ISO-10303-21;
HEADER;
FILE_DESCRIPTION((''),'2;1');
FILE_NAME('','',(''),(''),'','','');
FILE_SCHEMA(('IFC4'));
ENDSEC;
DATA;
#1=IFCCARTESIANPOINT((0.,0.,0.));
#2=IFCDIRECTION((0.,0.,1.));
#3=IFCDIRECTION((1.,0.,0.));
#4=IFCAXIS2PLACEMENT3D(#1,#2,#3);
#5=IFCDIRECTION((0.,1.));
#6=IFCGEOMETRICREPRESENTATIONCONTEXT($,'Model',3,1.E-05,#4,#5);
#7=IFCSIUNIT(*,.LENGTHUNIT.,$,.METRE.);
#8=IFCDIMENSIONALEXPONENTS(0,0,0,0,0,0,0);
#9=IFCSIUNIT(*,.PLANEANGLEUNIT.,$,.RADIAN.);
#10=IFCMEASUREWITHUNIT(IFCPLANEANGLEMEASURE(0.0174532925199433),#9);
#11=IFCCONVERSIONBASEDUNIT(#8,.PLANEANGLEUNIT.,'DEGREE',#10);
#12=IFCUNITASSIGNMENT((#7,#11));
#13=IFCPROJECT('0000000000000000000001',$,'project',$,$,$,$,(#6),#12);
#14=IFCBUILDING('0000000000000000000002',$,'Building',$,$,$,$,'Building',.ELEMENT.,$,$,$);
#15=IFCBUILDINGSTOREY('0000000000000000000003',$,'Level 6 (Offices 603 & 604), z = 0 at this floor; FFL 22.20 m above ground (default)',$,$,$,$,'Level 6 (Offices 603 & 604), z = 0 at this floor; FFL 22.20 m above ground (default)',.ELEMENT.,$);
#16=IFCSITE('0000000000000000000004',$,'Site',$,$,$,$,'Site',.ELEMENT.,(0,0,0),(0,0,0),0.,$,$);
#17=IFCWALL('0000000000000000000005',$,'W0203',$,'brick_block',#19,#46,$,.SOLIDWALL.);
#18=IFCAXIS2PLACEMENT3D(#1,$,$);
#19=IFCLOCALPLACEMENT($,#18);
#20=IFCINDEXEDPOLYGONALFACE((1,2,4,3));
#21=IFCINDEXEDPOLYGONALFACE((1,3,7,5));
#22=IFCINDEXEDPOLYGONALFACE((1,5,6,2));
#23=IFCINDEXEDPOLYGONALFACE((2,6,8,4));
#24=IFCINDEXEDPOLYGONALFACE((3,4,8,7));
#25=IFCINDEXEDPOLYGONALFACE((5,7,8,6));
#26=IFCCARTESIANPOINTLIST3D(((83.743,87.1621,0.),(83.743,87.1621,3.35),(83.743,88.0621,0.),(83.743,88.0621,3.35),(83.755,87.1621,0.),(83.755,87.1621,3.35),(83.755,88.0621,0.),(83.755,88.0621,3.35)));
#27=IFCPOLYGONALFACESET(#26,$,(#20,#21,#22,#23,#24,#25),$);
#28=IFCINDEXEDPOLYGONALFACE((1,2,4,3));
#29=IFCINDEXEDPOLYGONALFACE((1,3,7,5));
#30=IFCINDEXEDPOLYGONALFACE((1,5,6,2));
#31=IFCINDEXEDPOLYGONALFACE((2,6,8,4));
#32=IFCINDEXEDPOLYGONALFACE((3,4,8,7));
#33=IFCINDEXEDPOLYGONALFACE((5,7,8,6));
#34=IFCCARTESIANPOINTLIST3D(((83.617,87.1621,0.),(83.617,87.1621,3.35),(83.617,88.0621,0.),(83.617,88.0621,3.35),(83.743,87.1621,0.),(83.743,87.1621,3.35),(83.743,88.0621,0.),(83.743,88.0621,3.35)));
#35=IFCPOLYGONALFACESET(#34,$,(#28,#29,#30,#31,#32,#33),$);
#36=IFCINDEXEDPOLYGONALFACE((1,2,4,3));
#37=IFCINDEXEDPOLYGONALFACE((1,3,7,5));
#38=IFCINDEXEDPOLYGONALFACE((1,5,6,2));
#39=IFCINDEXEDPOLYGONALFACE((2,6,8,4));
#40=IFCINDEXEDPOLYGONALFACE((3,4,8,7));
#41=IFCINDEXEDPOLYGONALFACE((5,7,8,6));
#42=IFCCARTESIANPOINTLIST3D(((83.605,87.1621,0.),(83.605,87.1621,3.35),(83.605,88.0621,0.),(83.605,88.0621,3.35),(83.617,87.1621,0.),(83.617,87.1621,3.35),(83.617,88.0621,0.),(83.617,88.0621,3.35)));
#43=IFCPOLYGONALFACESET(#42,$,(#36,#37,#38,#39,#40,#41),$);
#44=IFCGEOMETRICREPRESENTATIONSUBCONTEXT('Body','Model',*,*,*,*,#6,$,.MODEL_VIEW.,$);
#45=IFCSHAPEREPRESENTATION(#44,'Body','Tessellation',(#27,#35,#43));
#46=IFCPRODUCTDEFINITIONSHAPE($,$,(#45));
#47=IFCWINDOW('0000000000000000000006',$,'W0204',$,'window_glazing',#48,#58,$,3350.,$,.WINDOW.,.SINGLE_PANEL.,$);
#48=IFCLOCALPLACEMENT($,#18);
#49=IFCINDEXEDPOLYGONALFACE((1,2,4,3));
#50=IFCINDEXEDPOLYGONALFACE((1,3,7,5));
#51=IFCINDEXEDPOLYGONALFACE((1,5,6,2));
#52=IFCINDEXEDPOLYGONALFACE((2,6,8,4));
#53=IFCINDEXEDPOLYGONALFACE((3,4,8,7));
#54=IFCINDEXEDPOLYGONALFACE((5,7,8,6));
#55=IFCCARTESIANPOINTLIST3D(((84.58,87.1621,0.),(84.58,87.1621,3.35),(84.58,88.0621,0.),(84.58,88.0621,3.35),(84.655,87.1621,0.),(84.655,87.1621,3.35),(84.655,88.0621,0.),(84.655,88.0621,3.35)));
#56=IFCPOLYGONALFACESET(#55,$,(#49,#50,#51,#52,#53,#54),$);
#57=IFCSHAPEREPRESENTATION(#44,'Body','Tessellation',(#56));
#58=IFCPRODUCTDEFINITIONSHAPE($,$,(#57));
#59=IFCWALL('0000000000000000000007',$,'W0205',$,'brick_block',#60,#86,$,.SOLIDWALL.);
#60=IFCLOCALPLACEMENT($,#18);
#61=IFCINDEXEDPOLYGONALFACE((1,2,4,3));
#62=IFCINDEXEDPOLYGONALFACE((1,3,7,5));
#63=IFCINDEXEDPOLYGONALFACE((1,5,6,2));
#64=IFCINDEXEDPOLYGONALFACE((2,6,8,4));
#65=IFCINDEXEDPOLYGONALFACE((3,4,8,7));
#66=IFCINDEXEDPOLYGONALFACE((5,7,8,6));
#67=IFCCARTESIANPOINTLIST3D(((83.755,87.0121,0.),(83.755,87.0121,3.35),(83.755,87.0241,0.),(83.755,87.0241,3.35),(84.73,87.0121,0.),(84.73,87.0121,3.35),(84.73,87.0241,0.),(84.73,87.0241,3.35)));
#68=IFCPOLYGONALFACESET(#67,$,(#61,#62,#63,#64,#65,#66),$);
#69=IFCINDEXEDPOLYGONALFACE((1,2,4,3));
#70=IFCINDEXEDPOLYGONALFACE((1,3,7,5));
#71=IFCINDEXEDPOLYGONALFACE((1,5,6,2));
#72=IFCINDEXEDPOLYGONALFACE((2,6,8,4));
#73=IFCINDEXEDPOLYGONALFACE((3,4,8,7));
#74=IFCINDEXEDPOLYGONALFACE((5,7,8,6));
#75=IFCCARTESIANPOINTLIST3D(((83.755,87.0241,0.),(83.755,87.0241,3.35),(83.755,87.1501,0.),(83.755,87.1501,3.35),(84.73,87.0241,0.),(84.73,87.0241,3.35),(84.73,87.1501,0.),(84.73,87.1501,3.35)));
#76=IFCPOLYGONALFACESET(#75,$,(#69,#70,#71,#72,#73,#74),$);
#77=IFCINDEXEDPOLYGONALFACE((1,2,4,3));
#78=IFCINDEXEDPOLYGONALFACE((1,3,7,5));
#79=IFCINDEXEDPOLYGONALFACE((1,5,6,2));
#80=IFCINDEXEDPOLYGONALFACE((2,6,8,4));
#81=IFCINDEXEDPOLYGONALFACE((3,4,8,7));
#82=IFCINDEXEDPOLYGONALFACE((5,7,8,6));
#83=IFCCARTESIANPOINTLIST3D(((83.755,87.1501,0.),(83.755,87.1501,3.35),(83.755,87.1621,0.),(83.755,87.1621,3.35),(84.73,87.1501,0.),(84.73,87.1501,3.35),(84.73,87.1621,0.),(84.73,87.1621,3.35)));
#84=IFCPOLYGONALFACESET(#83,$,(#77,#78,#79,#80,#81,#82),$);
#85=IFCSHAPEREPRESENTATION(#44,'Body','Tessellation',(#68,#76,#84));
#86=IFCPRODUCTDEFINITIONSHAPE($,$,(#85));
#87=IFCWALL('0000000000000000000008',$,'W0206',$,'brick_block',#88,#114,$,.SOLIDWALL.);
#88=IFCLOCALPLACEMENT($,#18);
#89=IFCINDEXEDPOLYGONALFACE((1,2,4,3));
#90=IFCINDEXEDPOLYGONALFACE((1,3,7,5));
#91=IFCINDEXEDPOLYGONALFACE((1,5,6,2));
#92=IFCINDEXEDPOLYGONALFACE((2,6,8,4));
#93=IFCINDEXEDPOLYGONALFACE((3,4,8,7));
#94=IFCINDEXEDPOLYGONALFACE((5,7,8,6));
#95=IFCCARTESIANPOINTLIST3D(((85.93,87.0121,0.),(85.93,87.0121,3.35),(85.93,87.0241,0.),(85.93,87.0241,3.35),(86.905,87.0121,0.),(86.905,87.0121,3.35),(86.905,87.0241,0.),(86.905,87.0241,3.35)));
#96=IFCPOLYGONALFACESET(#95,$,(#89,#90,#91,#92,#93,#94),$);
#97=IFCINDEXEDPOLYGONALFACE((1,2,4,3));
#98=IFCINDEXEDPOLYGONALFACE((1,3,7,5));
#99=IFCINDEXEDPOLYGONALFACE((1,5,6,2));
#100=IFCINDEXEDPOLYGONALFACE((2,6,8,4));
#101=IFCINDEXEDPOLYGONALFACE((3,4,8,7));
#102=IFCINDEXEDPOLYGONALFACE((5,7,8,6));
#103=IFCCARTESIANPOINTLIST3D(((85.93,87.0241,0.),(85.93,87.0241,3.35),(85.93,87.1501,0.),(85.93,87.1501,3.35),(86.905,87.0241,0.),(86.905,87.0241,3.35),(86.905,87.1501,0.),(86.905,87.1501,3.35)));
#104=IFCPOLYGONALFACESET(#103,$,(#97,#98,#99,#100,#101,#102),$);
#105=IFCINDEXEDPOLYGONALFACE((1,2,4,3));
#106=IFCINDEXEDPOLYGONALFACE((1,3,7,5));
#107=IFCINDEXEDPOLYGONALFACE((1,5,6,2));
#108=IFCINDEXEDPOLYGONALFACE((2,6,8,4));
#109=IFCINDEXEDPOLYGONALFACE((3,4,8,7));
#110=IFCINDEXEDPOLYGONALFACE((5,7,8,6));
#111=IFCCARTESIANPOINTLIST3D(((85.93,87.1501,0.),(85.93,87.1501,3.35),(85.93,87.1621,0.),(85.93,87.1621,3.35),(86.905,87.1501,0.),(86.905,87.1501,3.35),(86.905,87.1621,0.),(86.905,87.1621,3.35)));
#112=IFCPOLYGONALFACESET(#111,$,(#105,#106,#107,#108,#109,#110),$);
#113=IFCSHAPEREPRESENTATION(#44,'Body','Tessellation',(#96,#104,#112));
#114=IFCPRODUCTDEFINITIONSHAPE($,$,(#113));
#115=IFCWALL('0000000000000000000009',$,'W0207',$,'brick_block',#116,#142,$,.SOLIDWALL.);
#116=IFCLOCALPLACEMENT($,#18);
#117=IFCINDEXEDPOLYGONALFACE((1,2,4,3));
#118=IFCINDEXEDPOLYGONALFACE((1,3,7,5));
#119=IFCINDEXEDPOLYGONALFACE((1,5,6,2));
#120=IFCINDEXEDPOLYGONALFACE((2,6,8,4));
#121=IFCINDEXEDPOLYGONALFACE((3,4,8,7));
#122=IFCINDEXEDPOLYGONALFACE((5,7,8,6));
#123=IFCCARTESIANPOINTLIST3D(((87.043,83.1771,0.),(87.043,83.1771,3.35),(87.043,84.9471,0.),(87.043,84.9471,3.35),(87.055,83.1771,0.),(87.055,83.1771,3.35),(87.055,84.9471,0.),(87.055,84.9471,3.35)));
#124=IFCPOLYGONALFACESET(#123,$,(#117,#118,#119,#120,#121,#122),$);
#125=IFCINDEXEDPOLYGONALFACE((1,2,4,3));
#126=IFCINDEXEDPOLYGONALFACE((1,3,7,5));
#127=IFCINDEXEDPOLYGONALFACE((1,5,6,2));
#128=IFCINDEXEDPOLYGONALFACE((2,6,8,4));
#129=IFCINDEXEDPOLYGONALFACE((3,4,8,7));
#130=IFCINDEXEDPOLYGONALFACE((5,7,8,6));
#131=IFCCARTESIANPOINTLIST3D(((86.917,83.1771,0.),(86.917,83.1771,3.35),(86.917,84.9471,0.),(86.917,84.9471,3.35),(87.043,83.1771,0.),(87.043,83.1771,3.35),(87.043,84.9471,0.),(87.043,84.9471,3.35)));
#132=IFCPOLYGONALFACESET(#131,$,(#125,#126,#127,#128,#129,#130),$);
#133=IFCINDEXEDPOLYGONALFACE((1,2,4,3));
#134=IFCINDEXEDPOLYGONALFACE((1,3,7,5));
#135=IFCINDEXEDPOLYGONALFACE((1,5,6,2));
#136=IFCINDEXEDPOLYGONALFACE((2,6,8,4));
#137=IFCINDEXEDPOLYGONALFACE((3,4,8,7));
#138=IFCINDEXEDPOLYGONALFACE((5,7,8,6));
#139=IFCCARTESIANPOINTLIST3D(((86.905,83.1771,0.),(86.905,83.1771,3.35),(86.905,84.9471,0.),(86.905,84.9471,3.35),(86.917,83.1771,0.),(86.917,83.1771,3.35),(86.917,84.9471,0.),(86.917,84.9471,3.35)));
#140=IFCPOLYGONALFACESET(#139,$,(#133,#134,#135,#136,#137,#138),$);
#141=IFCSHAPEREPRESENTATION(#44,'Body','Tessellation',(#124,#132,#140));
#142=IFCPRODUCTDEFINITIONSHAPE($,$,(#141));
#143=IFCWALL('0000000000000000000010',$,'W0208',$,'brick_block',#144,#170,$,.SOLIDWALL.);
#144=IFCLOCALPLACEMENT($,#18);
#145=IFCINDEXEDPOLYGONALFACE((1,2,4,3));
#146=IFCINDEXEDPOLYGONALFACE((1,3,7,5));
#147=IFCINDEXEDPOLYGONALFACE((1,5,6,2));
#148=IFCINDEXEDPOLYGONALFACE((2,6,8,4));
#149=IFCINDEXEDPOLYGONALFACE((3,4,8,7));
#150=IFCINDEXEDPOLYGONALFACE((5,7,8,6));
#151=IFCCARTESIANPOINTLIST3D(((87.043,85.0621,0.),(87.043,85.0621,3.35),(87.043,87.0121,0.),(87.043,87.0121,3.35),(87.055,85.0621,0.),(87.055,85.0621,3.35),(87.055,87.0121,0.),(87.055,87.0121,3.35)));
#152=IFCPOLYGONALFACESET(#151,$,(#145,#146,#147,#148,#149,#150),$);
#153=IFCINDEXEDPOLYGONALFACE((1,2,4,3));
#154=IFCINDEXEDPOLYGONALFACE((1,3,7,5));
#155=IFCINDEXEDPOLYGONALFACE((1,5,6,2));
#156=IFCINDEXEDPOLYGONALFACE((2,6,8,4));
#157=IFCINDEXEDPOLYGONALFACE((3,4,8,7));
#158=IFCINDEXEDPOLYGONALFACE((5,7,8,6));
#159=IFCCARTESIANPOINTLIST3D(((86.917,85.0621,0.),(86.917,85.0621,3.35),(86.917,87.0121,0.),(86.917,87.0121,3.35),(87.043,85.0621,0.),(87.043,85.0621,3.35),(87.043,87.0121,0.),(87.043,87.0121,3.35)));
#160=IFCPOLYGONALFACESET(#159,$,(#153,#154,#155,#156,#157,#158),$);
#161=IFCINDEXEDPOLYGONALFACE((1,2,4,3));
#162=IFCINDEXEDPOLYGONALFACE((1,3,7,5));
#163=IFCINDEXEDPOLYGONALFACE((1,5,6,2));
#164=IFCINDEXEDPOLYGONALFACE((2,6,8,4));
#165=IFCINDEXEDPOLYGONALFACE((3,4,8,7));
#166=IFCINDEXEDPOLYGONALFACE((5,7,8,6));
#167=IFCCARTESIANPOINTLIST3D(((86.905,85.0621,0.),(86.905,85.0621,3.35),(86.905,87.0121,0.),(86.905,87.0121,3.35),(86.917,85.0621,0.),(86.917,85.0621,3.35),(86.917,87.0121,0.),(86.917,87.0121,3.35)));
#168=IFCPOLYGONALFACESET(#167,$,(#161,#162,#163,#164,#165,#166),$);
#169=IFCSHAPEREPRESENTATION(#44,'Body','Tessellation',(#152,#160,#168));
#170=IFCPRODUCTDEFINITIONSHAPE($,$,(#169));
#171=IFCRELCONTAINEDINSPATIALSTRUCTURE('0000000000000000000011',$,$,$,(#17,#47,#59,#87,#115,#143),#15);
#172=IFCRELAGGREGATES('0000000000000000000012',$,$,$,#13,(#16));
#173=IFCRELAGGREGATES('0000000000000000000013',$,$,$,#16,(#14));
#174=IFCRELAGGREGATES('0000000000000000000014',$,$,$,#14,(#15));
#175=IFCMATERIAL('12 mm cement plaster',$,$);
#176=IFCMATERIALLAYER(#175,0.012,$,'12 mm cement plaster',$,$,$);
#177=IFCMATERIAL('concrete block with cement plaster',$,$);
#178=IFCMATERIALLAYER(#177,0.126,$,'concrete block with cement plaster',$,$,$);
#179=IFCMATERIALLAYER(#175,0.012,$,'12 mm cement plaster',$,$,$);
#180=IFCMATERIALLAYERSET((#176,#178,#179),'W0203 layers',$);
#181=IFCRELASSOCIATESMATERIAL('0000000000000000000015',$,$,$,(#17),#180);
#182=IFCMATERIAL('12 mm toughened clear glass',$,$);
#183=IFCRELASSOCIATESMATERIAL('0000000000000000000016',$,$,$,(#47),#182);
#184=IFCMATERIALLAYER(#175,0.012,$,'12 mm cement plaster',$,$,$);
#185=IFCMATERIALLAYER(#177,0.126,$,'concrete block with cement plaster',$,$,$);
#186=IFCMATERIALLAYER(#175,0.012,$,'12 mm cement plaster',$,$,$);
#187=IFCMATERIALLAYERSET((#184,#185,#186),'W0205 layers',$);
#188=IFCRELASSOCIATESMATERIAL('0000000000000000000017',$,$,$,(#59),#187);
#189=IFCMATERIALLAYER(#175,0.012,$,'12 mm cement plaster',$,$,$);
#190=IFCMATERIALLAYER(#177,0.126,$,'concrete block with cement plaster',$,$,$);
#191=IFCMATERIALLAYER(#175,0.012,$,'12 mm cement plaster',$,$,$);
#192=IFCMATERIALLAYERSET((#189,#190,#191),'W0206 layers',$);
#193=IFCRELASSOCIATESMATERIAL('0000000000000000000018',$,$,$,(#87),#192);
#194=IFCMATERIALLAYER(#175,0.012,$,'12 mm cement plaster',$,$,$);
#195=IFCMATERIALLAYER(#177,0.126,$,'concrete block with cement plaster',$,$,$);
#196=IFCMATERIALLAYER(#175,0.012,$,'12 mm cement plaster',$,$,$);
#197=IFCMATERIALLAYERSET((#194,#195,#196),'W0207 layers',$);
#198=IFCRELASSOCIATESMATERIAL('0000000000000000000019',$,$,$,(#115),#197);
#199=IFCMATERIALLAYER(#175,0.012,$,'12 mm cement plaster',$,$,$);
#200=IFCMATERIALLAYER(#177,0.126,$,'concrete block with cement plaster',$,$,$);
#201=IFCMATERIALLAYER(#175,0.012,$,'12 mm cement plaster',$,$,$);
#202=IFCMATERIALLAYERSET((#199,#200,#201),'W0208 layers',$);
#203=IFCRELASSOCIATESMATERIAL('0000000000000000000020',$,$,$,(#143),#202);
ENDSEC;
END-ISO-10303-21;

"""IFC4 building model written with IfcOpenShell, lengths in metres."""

from ifc_helpers import new_model, entity, si_unit, converted_unit, direction, frame, frame_2d, origin_with_axes, origin_2d_with_axis, place, context, subcontext, project, spatial, rectangle, extrude, material, layer, layer_set, layer_usage, element, save


model = new_model("IFC4")

# Units and contexts
model_context = context("Model", 3, precision=1e-05, world=origin_with_axes(), true_north=direction((0.0, 1.0)))
body_context = subcontext(model_context, "Body", "Model", "MODEL_VIEW")
ifc_project = project(units=[si_unit("LENGTHUNIT", "METRE"), converted_unit("PLANEANGLEUNIT", "DEGREE", entity("IfcPlaneAngleMeasure", 0.0174532925199433), si_unit("PLANEANGLEUNIT", "RADIAN"), dimensions=[0, 0, 0, 0, 0, 0, 0])], contexts=[model_context])

# Site, building, storey
site = spatial("IfcSite", under=ifc_project, Name="Site", LongName="Site", CompositionType="ELEMENT", RefLatitude=(0, 0, 0), RefLongitude=(0, 0, 0), RefElevation=0.0)
building = spatial("IfcBuilding", under=site, Name="Building", LongName="Building", CompositionType="ELEMENT")
storey = spatial("IfcBuildingStorey", under=building, Name="Level 6 (Offices 603 & 604), z = 0 at this floor; FFL 22.20 m above ground (default)", LongName="Level 6 (Offices 603 & 604), z = 0 at this floor; FFL 22.20 m above ground (default)", CompositionType="ELEMENT")

# Wall
ifc_material_1 = material(Name="12 mm cement plaster")
ifc_material_2 = material(Name="concrete block with cement plaster")
placement = place(None, origin_with_axes())
ifc_layer_1 = layer(ifc_material_1, 0.012, Name="12 mm cement plaster")
ifc_layer_2 = layer(ifc_material_2, 0.126, Name="concrete block with cement plaster")
ifc_layer_3 = layer(ifc_material_1, 0.012, Name="12 mm cement plaster")
ifc_layer_set_1 = layer_set([ifc_layer_1, ifc_layer_2, ifc_layer_3], Name="W0203 layers")
ifc_layer_usage_1 = layer_usage(ifc_layer_set_1, "AXIS2", "POSITIVE", -0.075)
element("IfcWall", 1, at=placement, inside=storey, material=ifc_layer_usage_1, Name="W0203", ObjectType="brick_block", PredefinedType="SOLIDWALL", context=body_context, shape_type="SweptSolid", body=[
    extrude(rectangle(XDim=0.9, YDim=0.012, at=frame_2d((0.0, 0.0), x_axis=(0.0, 1.0))), frame((83.749, 87.6121, 0.0), z_axis=(0.0, 0.0, 1.0), x_axis=(1.0, 0.0, 0.0)), (0.0, 0.0, 1.0), 3.35),
    extrude(rectangle(XDim=0.9, YDim=0.126, at=frame_2d((-0.069, 0.0), x_axis=(0.0, 1.0))), frame((83.749, 87.6121, 0.0), z_axis=(0.0, 0.0, 1.0), x_axis=(1.0, 0.0, 0.0)), (0.0, 0.0, 1.0), 3.35),
    extrude(rectangle(XDim=0.9, YDim=0.012, at=frame_2d((-0.138, 0.0), x_axis=(0.0, 1.0))), frame((83.749, 87.6121, 0.0), z_axis=(0.0, 0.0, 1.0), x_axis=(1.0, 0.0, 0.0)), (0.0, 0.0, 1.0), 3.35),
])

# Window
ifc_material_3 = material(Name="12 mm toughened clear glass")
element("IfcWindow", 2, at=placement, inside=storey, material=ifc_material_3, Name="W0204", ObjectType="window_glazing", OverallHeight=3350.0, PartitioningType="SINGLE_PANEL", PredefinedType="WINDOW", context=body_context, shape_type="SweptSolid", body=[
    extrude(rectangle(XDim=0.9, YDim=0.075, at=frame_2d((0.0, 0.0), x_axis=(0.0, 1.0))), frame((84.6175, 87.6121, 0.0), z_axis=(0.0, 0.0, 1.0), x_axis=(1.0, 0.0, 0.0)), (0.0, 0.0, 1.0), 3.35),
])

# Walls
ifc_layer_4 = layer(ifc_material_1, 0.012, Name="12 mm cement plaster")
ifc_layer_5 = layer(ifc_material_2, 0.126, Name="concrete block with cement plaster")
ifc_layer_6 = layer(ifc_material_1, 0.012, Name="12 mm cement plaster")
ifc_layer_set_2 = layer_set([ifc_layer_4, ifc_layer_5, ifc_layer_6], Name="W0205 layers")
ifc_layer_usage_2 = layer_usage(ifc_layer_set_2, "AXIS2", "POSITIVE", -0.075)
element("IfcWall", 3, at=placement, inside=storey, material=ifc_layer_usage_2, Name="W0205", ObjectType="brick_block", PredefinedType="SOLIDWALL", context=body_context, shape_type="SweptSolid", body=[
    extrude(rectangle(XDim=0.975, YDim=0.012, at=origin_2d_with_axis()), frame((84.2425, 87.0181, 0.0), z_axis=(0.0, 0.0, 1.0), x_axis=(1.0, 0.0, 0.0)), (0.0, 0.0, 1.0), 3.35),
    extrude(rectangle(XDim=0.975, YDim=0.126, at=frame_2d((0.0, 0.069), x_axis=(1.0, 0.0))), frame((84.2425, 87.0181, 0.0), z_axis=(0.0, 0.0, 1.0), x_axis=(1.0, 0.0, 0.0)), (0.0, 0.0, 1.0), 3.35),
    extrude(rectangle(XDim=0.975, YDim=0.012, at=frame_2d((0.0, 0.138), x_axis=(1.0, 0.0))), frame((84.2425, 87.0181, 0.0), z_axis=(0.0, 0.0, 1.0), x_axis=(1.0, 0.0, 0.0)), (0.0, 0.0, 1.0), 3.35),
])
ifc_layer_7 = layer(ifc_material_1, 0.012, Name="12 mm cement plaster")
ifc_layer_8 = layer(ifc_material_2, 0.126, Name="concrete block with cement plaster")
ifc_layer_9 = layer(ifc_material_1, 0.012, Name="12 mm cement plaster")
ifc_layer_set_3 = layer_set([ifc_layer_7, ifc_layer_8, ifc_layer_9], Name="W0206 layers")
ifc_layer_usage_3 = layer_usage(ifc_layer_set_3, "AXIS2", "POSITIVE", -0.075)
element("IfcWall", 4, at=placement, inside=storey, material=ifc_layer_usage_3, Name="W0206", ObjectType="brick_block", PredefinedType="SOLIDWALL", context=body_context, shape_type="SweptSolid", body=[
    extrude(rectangle(XDim=0.975, YDim=0.012, at=origin_2d_with_axis()), frame((86.4175, 87.0181, 0.0), z_axis=(0.0, 0.0, 1.0), x_axis=(1.0, 0.0, 0.0)), (0.0, 0.0, 1.0), 3.35),
    extrude(rectangle(XDim=0.975, YDim=0.126, at=frame_2d((0.0, 0.069), x_axis=(1.0, 0.0))), frame((86.4175, 87.0181, 0.0), z_axis=(0.0, 0.0, 1.0), x_axis=(1.0, 0.0, 0.0)), (0.0, 0.0, 1.0), 3.35),
    extrude(rectangle(XDim=0.975, YDim=0.012, at=frame_2d((0.0, 0.138), x_axis=(1.0, 0.0))), frame((86.4175, 87.0181, 0.0), z_axis=(0.0, 0.0, 1.0), x_axis=(1.0, 0.0, 0.0)), (0.0, 0.0, 1.0), 3.35),
])
ifc_layer_10 = layer(ifc_material_1, 0.012, Name="12 mm cement plaster")
ifc_layer_11 = layer(ifc_material_2, 0.126, Name="concrete block with cement plaster")
ifc_layer_12 = layer(ifc_material_1, 0.012, Name="12 mm cement plaster")
ifc_layer_set_4 = layer_set([ifc_layer_10, ifc_layer_11, ifc_layer_12], Name="W0207 layers")
ifc_layer_usage_4 = layer_usage(ifc_layer_set_4, "AXIS2", "POSITIVE", -0.075)
element("IfcWall", 5, at=placement, inside=storey, material=ifc_layer_usage_4, Name="W0207", ObjectType="brick_block", PredefinedType="SOLIDWALL", context=body_context, shape_type="SweptSolid", body=[
    extrude(rectangle(XDim=1.77, YDim=0.012, at=frame_2d((0.0, 0.0), x_axis=(0.0, 1.0))), frame((87.049, 84.0621, 0.0), z_axis=(0.0, 0.0, 1.0), x_axis=(1.0, 0.0, 0.0)), (0.0, 0.0, 1.0), 3.35),
    extrude(rectangle(XDim=1.77, YDim=0.126, at=frame_2d((-0.069, 0.0), x_axis=(0.0, 1.0))), frame((87.049, 84.0621, 0.0), z_axis=(0.0, 0.0, 1.0), x_axis=(1.0, 0.0, 0.0)), (0.0, 0.0, 1.0), 3.35),
    extrude(rectangle(XDim=1.77, YDim=0.012, at=frame_2d((-0.138, 0.0), x_axis=(0.0, 1.0))), frame((87.049, 84.0621, 0.0), z_axis=(0.0, 0.0, 1.0), x_axis=(1.0, 0.0, 0.0)), (0.0, 0.0, 1.0), 3.35),
])
ifc_layer_13 = layer(ifc_material_1, 0.012, Name="12 mm cement plaster")
ifc_layer_14 = layer(ifc_material_2, 0.126, Name="concrete block with cement plaster")
ifc_layer_15 = layer(ifc_material_1, 0.012, Name="12 mm cement plaster")
ifc_layer_set_5 = layer_set([ifc_layer_13, ifc_layer_14, ifc_layer_15], Name="W0208 layers")
ifc_layer_usage_5 = layer_usage(ifc_layer_set_5, "AXIS2", "POSITIVE", -0.075)
element("IfcWall", 6, at=placement, inside=storey, material=ifc_layer_usage_5, Name="W0208", ObjectType="brick_block", PredefinedType="SOLIDWALL", context=body_context, shape_type="SweptSolid", body=[
    extrude(rectangle(XDim=1.95, YDim=0.012, at=frame_2d((0.0, 0.0), x_axis=(0.0, 1.0))), frame((87.049, 86.0371, 0.0), z_axis=(0.0, 0.0, 1.0), x_axis=(1.0, 0.0, 0.0)), (0.0, 0.0, 1.0), 3.35),
    extrude(rectangle(XDim=1.95, YDim=0.126, at=frame_2d((-0.069, 0.0), x_axis=(0.0, 1.0))), frame((87.049, 86.0371, 0.0), z_axis=(0.0, 0.0, 1.0), x_axis=(1.0, 0.0, 0.0)), (0.0, 0.0, 1.0), 3.35),
    extrude(rectangle(XDim=1.95, YDim=0.012, at=frame_2d((-0.138, 0.0), x_axis=(0.0, 1.0))), frame((87.049, 86.0371, 0.0), z_axis=(0.0, 0.0, 1.0), x_axis=(1.0, 0.0, 0.0)), (0.0, 0.0, 1.0), 3.35),
])

save(model, "model.ifc")
